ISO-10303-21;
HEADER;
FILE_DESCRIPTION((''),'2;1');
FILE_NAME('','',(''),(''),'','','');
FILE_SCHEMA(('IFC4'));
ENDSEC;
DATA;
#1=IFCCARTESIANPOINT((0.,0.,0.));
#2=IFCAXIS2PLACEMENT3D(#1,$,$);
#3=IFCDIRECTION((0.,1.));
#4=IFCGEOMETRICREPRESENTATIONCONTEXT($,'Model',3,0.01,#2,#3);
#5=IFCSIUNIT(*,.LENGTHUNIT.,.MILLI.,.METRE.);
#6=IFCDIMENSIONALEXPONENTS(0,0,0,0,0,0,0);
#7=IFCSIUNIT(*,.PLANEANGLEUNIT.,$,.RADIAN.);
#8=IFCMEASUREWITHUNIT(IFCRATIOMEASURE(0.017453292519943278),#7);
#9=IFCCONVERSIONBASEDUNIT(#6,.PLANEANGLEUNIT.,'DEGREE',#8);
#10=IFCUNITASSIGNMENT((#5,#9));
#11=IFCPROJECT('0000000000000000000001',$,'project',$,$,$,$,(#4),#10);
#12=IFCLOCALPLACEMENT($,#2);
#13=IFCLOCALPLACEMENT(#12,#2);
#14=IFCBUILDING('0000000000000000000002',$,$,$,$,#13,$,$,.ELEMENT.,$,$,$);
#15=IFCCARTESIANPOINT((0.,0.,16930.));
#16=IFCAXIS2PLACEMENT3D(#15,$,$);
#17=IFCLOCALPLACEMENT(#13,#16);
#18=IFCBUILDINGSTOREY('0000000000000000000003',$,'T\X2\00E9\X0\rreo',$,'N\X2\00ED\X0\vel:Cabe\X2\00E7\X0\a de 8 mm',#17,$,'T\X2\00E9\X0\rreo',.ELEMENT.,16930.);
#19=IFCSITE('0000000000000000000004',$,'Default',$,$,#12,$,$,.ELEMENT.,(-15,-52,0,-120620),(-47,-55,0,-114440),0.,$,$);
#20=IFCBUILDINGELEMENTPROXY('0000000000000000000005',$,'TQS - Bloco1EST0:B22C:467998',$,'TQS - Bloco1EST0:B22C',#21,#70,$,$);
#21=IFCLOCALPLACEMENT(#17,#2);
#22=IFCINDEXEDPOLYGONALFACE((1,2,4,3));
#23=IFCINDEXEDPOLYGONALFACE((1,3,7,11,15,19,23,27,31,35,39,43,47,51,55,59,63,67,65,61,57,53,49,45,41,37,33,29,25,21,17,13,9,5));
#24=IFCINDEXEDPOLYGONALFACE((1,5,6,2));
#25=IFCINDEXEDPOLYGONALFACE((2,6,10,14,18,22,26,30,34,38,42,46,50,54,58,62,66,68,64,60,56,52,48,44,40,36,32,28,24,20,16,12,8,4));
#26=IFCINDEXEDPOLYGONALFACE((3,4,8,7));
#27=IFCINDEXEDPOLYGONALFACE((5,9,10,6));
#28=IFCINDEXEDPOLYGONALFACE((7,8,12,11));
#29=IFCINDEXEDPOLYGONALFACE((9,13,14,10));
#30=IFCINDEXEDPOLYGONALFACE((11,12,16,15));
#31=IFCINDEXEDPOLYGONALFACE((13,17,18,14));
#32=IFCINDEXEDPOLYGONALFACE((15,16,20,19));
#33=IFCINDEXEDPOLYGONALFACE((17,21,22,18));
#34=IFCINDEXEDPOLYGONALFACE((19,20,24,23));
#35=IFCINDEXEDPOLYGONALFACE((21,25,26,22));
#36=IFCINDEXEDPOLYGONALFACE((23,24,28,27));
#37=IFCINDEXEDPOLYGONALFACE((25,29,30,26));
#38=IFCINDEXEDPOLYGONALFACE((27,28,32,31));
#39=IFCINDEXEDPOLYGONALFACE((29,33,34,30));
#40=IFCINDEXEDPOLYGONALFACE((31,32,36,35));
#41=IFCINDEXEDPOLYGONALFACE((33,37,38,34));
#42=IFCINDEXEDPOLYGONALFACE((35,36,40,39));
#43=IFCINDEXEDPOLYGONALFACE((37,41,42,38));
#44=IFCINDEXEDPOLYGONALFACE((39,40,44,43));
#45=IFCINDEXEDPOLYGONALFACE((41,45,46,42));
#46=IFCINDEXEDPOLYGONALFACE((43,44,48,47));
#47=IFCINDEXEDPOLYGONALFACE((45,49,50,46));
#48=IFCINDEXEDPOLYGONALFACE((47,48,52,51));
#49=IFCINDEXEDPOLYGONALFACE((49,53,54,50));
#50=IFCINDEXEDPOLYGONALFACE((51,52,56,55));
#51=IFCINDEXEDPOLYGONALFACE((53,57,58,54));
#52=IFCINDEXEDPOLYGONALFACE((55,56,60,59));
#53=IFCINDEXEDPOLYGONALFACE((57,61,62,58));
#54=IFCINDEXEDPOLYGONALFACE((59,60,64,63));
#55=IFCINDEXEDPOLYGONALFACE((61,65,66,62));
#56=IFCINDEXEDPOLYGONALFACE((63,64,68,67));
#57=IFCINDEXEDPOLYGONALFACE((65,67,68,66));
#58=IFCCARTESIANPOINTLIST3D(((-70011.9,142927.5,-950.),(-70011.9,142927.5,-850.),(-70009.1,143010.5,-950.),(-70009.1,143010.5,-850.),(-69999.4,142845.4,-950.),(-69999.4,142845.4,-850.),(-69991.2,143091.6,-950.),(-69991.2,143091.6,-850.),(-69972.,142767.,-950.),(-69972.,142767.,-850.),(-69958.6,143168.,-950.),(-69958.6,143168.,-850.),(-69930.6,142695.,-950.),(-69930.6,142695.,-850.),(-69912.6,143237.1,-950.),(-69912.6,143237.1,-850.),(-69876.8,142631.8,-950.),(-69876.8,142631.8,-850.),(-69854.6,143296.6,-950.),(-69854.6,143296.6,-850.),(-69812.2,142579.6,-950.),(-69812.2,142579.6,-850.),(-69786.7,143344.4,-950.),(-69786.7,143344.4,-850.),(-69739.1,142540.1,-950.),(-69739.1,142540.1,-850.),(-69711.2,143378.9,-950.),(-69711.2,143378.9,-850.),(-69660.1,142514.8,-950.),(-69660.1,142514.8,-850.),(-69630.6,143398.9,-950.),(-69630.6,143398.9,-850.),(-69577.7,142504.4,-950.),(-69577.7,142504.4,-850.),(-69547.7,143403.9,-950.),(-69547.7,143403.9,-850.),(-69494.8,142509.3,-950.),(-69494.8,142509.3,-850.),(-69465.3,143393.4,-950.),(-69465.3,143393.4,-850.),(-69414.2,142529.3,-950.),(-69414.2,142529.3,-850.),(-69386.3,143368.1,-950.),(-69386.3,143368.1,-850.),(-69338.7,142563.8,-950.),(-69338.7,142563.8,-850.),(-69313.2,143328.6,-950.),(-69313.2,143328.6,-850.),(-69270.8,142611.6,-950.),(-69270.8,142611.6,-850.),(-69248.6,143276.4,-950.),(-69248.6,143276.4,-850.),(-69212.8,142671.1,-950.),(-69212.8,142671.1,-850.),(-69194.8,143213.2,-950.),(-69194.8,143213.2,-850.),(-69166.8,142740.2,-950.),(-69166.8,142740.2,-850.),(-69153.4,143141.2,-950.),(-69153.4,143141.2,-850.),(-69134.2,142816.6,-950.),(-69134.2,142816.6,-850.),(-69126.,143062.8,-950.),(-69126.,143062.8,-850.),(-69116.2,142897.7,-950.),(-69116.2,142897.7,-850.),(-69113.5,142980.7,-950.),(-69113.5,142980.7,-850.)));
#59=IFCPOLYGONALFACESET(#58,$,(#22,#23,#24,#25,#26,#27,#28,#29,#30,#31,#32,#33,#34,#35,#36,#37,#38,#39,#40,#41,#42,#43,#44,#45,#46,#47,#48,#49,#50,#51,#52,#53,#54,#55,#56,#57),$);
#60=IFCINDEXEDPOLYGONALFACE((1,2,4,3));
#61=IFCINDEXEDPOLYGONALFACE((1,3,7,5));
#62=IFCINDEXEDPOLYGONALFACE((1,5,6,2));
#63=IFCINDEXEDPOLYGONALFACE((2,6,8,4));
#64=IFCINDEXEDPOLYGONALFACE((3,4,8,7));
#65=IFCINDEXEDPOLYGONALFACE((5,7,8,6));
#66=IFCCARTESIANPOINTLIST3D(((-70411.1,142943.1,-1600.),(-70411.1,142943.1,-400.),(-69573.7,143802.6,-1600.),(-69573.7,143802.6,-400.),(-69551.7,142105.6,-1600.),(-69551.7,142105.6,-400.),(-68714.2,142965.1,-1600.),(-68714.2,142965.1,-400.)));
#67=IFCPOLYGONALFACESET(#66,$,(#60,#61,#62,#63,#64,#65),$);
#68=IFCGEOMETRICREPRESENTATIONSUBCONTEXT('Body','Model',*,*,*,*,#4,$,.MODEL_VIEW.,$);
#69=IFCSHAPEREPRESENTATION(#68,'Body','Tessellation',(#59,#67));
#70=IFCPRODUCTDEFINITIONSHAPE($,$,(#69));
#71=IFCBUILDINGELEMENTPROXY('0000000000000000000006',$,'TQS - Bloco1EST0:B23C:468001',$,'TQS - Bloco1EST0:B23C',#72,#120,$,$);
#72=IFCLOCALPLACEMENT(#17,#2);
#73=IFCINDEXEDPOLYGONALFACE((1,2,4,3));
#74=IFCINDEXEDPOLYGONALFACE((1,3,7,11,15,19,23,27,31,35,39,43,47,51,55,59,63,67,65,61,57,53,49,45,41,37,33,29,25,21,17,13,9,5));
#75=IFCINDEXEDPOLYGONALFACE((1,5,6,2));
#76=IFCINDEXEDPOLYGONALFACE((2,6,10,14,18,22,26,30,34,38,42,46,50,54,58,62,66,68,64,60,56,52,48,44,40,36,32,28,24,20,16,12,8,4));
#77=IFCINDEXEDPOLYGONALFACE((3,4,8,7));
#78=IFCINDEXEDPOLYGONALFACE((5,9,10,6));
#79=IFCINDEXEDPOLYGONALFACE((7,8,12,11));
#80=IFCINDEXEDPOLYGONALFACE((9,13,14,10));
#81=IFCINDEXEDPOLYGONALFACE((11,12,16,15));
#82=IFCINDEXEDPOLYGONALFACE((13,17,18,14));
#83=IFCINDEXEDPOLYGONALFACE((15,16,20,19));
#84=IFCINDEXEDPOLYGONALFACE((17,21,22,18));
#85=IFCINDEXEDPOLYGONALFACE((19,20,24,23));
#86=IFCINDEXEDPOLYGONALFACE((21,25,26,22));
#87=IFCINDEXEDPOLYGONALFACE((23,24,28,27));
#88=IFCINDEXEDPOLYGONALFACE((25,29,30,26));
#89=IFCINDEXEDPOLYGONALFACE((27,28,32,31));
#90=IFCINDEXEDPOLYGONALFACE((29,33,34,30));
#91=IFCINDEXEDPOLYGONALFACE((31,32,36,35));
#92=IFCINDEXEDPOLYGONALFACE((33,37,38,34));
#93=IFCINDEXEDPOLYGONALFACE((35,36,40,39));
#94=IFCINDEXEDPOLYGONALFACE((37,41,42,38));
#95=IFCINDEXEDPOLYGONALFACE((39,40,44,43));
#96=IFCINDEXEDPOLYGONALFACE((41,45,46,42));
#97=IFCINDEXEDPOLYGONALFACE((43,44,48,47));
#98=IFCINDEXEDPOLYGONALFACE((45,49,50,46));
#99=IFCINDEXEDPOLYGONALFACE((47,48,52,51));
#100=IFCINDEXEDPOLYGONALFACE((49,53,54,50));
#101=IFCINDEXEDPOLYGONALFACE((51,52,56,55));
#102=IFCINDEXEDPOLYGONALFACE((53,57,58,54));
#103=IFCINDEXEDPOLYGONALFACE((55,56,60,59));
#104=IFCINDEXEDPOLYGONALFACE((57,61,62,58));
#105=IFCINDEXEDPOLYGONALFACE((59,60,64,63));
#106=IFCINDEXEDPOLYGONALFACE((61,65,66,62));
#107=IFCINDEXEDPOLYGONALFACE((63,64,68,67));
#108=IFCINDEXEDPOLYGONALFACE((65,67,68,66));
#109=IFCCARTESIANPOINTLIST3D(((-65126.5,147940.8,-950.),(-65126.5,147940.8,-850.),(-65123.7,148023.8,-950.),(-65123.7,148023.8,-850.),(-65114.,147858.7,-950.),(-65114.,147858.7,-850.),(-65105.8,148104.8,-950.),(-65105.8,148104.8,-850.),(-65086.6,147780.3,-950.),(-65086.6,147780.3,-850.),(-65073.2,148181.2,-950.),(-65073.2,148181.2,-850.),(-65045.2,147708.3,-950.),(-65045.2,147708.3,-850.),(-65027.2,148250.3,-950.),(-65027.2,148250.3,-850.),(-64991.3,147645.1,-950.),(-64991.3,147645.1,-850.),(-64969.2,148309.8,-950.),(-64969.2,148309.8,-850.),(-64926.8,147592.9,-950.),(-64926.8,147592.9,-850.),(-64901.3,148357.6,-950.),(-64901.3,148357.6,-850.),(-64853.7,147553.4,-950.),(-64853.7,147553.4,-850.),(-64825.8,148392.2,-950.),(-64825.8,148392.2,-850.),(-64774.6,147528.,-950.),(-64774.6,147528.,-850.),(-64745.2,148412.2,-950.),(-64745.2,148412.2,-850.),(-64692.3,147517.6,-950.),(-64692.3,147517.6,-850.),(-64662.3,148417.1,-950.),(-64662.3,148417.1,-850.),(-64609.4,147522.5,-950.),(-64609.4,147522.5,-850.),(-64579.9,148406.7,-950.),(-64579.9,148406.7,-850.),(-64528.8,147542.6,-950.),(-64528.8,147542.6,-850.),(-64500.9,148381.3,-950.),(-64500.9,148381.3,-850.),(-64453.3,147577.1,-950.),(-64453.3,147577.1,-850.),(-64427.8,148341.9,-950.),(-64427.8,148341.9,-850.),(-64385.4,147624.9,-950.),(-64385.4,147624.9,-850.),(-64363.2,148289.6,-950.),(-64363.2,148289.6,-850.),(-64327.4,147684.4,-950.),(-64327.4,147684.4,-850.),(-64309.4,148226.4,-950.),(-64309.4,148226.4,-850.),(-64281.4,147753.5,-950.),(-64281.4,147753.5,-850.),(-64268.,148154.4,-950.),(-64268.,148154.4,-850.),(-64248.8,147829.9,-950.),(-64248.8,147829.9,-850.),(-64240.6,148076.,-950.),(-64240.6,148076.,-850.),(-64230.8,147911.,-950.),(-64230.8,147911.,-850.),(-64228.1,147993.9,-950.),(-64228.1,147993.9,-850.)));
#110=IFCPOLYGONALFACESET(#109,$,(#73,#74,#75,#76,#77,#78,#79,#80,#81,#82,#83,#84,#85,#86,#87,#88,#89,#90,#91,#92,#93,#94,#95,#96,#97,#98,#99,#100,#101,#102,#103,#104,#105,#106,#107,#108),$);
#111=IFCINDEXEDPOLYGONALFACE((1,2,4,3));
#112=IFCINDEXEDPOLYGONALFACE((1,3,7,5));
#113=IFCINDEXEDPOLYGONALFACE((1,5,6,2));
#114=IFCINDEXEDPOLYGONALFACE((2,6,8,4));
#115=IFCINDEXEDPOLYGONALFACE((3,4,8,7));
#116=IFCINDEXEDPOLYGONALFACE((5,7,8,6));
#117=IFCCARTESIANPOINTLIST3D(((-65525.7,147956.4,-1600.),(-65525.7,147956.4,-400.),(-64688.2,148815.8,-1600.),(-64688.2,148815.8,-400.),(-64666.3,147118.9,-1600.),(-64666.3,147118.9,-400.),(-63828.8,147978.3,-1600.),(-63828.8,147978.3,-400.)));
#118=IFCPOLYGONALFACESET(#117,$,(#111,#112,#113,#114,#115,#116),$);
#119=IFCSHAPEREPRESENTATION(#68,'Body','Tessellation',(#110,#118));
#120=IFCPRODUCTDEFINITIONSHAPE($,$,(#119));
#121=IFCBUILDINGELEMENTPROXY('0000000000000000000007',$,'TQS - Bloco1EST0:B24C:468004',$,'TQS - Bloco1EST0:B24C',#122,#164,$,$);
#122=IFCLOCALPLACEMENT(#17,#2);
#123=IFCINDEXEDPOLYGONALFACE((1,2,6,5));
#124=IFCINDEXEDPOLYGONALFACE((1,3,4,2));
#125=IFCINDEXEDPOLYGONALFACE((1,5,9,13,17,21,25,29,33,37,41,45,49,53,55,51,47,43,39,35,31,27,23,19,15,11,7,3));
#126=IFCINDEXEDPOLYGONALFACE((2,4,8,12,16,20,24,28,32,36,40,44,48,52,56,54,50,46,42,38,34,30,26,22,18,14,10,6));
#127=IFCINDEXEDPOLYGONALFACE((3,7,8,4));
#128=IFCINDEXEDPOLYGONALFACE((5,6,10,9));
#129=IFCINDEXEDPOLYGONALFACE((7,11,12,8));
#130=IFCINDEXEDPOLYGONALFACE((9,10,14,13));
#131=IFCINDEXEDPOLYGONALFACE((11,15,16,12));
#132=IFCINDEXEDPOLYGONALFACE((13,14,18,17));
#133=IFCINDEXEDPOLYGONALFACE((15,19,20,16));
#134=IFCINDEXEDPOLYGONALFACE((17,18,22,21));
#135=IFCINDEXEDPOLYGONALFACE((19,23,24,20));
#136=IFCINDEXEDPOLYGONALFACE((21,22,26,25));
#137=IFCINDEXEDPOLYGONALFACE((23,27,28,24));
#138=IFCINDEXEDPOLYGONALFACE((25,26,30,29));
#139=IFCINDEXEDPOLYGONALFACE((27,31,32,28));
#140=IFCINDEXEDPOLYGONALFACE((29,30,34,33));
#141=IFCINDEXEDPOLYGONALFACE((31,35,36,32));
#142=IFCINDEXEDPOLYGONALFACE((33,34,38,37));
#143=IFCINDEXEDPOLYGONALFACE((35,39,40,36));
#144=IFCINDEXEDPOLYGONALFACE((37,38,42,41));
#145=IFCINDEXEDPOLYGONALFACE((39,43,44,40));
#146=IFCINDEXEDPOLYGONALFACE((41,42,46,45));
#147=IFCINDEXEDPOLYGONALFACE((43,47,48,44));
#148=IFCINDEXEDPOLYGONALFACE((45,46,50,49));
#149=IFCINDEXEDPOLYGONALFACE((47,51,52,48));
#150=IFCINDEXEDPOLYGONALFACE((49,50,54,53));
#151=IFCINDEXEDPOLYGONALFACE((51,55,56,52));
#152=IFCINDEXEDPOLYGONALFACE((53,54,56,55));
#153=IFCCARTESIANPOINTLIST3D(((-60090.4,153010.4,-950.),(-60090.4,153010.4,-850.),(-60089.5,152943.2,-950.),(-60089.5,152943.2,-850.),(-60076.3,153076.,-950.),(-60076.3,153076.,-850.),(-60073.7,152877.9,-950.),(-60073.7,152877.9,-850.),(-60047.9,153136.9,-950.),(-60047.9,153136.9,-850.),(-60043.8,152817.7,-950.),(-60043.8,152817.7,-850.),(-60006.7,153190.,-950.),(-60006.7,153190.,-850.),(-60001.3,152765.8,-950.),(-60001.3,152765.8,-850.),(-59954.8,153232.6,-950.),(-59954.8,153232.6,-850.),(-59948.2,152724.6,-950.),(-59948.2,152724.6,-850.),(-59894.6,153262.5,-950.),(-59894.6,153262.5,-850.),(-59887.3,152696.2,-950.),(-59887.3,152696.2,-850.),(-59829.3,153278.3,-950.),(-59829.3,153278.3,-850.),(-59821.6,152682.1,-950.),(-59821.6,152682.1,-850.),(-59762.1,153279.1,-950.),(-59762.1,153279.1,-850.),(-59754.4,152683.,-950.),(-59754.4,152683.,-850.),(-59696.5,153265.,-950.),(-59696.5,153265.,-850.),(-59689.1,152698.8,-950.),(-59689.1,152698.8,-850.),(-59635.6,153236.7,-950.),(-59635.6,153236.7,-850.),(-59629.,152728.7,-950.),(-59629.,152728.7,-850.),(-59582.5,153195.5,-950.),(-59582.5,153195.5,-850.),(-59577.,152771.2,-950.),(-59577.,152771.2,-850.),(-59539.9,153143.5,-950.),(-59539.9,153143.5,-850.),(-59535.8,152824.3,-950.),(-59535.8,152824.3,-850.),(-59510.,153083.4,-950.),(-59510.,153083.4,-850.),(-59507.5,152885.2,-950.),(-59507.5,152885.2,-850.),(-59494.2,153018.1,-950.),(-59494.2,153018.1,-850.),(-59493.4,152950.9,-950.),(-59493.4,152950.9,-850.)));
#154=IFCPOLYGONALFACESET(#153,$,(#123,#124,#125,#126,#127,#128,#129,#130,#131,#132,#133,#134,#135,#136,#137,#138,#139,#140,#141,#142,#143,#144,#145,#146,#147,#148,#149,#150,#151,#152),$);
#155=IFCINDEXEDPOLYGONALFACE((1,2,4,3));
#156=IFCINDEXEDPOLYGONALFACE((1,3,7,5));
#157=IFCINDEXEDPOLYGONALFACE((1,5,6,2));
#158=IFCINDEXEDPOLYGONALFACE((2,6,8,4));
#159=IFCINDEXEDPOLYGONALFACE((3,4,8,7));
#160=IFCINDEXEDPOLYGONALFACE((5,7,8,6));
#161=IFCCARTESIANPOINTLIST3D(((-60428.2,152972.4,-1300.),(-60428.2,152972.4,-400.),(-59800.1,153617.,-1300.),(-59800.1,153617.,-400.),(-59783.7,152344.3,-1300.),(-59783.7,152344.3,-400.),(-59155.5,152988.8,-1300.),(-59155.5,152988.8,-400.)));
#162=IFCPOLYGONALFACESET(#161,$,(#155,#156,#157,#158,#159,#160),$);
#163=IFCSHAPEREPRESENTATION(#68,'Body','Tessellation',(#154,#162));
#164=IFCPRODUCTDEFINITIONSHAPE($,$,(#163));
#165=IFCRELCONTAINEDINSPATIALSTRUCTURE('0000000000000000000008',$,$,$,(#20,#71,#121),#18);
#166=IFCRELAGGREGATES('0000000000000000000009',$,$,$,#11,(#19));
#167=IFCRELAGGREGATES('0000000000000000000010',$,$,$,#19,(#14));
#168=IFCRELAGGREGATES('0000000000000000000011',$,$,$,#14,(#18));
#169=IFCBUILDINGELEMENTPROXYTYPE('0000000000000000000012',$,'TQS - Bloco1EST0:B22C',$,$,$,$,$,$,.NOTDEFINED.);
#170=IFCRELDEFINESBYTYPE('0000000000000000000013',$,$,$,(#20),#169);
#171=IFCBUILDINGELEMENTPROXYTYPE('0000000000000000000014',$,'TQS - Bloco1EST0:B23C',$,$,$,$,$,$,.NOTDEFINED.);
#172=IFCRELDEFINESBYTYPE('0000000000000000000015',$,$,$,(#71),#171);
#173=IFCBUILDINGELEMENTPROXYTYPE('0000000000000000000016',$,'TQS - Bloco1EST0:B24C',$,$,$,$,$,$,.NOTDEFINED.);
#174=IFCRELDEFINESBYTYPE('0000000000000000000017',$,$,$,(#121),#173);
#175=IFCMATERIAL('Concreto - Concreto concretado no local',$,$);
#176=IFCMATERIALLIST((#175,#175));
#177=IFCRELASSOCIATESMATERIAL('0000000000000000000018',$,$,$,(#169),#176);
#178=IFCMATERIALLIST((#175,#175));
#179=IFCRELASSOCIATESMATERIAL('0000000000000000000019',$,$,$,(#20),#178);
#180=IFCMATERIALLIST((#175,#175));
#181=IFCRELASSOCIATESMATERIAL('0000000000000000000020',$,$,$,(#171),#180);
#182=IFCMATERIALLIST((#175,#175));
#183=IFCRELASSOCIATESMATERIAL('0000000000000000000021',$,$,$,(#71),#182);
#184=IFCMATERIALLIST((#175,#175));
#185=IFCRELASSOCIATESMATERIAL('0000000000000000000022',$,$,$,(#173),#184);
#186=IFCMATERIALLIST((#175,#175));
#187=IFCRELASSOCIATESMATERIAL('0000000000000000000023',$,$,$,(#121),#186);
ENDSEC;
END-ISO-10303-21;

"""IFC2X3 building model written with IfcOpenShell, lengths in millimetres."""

from ifc_helpers import new_model, entity, si_unit, converted_unit, direction, frame, frame_2d, origin, origin_2d_with_axis, place, context, subcontext, project, spatial, rectangle, circle, extrude, source, transform, mapped, material, material_list, type_object, type_shapes, element, save


model = new_model("IFC2X3")

# Units and contexts
model_context = context("Model", 3, precision=0.01, world=origin(), true_north=direction((0.0, 1.0)))
body_context = subcontext(model_context, "Body", "Model", "MODEL_VIEW")
ifc_project = project(units=[si_unit("LENGTHUNIT", "METRE", prefix="MILLI"), converted_unit("PLANEANGLEUNIT", "DEGREE", entity("IfcRatioMeasure", 0.017453292519943278), si_unit("PLANEANGLEUNIT", "RADIAN"), dimensions=[0, 0, 0, 0, 0, 0, 0])], contexts=[model_context])

# Site, building, storey
site_placement = place(None, origin())
site = spatial("IfcSite", under=ifc_project, at=site_placement, Name="Default", CompositionType="ELEMENT", RefLatitude=(-15, -52, 0, -120620), RefLongitude=(-47, -55, 0, -114440), RefElevation=0.0)
building_placement = place(site_placement, origin())
building = spatial("IfcBuilding", under=site, at=building_placement, CompositionType="ELEMENT")
storey_placement = place(building_placement, frame((0.0, 0.0, 16930.0)))
storey = spatial("IfcBuildingStorey", under=building, at=storey_placement, Name="Térreo", ObjectType="Nível:Cabeça de 8 mm", LongName="Térreo", CompositionType="ELEMENT", Elevation=16930.0)

# Building element proxies
ifc_material_1 = material(Name="Concreto - Concreto concretado no local")
ifc_material_list_1 = material_list([ifc_material_1, ifc_material_1])
ifc_material_list_2 = material_list([ifc_material_1, ifc_material_1])
building_element_proxy_type_1 = type_object("IfcBuildingElementProxyType", Name="TQS - Bloco1EST0:B22C", PredefinedType="NOTDEFINED", material=ifc_material_list_2)
shared_shape_1 = source(origin(), body_context, "Body", "SweptSolid", [
    extrude(circle(Radius=450.0, at=frame_2d((0.0, 0.0), x_axis=(1.0, 0.0))), frame((0.0, 0.0, -550.0)), (0.0, 0.0, 1.0), 100.0),
    extrude(rectangle(XDim=1200.0, YDim=1200.0, at=origin_2d_with_axis()), frame((0.0, 0.0, -1200.0), z_axis=(0.0, 0.0, 1.0), x_axis=(-1.0, 0.0, 0.0)), (0.0, 0.0, 1.0), 1200.0),
])
type_shapes(building_element_proxy_type_1, [shared_shape_1])
proxy_1_placement = place(storey_placement, frame((-69562.7, 142954.1, -400.0), z_axis=(0.0, 0.0, 1.0), x_axis=(0.697915, 0.71618, 0.0)))
element("IfcBuildingElementProxy", 1, at=proxy_1_placement, inside=storey, type_object=building_element_proxy_type_1, material=ifc_material_list_1, Name="TQS - Bloco1EST0:B22C:467998", ObjectType="TQS - Bloco1EST0:B22C", context=body_context, shape_type="MappedRepresentation", body=[
    mapped(shared_shape_1, transform((0.0, 0.0, 0.0), scale=1.0)),
])
ifc_material_list_3 = material_list([ifc_material_1, ifc_material_1])
ifc_material_list_4 = material_list([ifc_material_1, ifc_material_1])
building_element_proxy_type_2 = type_object("IfcBuildingElementProxyType", Name="TQS - Bloco1EST0:B23C", PredefinedType="NOTDEFINED", material=ifc_material_list_4)
shared_shape_2 = source(origin(), body_context, "Body", "SweptSolid", [
    extrude(circle(Radius=450.0, at=frame_2d((0.0, 0.0), x_axis=(1.0, 0.0))), frame((0.0, 0.0, -550.0)), (0.0, 0.0, 1.0), 100.0),
    extrude(rectangle(XDim=1200.0, YDim=1200.0, at=origin_2d_with_axis()), frame((0.0, 0.0, -1200.0), z_axis=(0.0, 0.0, 1.0), x_axis=(-1.0, 0.0, 0.0)), (0.0, 0.0, 1.0), 1200.0),
])
type_shapes(building_element_proxy_type_2, [shared_shape_2])
proxy_2_placement = place(storey_placement, frame((-64677.3, 147967.4, -400.0), z_axis=(0.0, 0.0, 1.0), x_axis=(0.697915, 0.71618, 0.0)))
element("IfcBuildingElementProxy", 2, at=proxy_2_placement, inside=storey, type_object=building_element_proxy_type_2, material=ifc_material_list_3, Name="TQS - Bloco1EST0:B23C:468001", ObjectType="TQS - Bloco1EST0:B23C", context=body_context, shape_type="MappedRepresentation", body=[
    mapped(shared_shape_2, transform((0.0, 0.0, 0.0), scale=1.0)),
])
ifc_material_list_5 = material_list([ifc_material_1, ifc_material_1])
ifc_material_list_6 = material_list([ifc_material_1, ifc_material_1])
building_element_proxy_type_3 = type_object("IfcBuildingElementProxyType", Name="TQS - Bloco1EST0:B24C", PredefinedType="NOTDEFINED", material=ifc_material_list_6)
shared_shape_3 = source(origin(), body_context, "Body", "SweptSolid", [
    extrude(circle(Radius=300.0, at=frame_2d((0.0, 0.0), x_axis=(1.0, 0.0))), frame((0.0, 0.0, -550.0)), (0.0, 0.0, 1.0), 100.0),
    extrude(rectangle(XDim=900.0, YDim=900.0, at=origin_2d_with_axis()), frame((0.0, 0.0, -900.0), z_axis=(0.0, 0.0, 1.0), x_axis=(-1.0, 0.0, 0.0)), (0.0, 0.0, 1.0), 900.0),
])
type_shapes(building_element_proxy_type_3, [shared_shape_3])
proxy_3_placement = place(storey_placement, frame((-59791.9, 152980.6, -400.0), z_axis=(0.0, 0.0, 1.0), x_axis=(0.697915, 0.71618, 0.0)))
element("IfcBuildingElementProxy", 3, at=proxy_3_placement, inside=storey, type_object=building_element_proxy_type_3, material=ifc_material_list_5, Name="TQS - Bloco1EST0:B24C:468004", ObjectType="TQS - Bloco1EST0:B24C", context=body_context, shape_type="MappedRepresentation", body=[
    mapped(shared_shape_3, transform((0.0, 0.0, 0.0), scale=1.0)),
])

save(model, "model.ifc")
